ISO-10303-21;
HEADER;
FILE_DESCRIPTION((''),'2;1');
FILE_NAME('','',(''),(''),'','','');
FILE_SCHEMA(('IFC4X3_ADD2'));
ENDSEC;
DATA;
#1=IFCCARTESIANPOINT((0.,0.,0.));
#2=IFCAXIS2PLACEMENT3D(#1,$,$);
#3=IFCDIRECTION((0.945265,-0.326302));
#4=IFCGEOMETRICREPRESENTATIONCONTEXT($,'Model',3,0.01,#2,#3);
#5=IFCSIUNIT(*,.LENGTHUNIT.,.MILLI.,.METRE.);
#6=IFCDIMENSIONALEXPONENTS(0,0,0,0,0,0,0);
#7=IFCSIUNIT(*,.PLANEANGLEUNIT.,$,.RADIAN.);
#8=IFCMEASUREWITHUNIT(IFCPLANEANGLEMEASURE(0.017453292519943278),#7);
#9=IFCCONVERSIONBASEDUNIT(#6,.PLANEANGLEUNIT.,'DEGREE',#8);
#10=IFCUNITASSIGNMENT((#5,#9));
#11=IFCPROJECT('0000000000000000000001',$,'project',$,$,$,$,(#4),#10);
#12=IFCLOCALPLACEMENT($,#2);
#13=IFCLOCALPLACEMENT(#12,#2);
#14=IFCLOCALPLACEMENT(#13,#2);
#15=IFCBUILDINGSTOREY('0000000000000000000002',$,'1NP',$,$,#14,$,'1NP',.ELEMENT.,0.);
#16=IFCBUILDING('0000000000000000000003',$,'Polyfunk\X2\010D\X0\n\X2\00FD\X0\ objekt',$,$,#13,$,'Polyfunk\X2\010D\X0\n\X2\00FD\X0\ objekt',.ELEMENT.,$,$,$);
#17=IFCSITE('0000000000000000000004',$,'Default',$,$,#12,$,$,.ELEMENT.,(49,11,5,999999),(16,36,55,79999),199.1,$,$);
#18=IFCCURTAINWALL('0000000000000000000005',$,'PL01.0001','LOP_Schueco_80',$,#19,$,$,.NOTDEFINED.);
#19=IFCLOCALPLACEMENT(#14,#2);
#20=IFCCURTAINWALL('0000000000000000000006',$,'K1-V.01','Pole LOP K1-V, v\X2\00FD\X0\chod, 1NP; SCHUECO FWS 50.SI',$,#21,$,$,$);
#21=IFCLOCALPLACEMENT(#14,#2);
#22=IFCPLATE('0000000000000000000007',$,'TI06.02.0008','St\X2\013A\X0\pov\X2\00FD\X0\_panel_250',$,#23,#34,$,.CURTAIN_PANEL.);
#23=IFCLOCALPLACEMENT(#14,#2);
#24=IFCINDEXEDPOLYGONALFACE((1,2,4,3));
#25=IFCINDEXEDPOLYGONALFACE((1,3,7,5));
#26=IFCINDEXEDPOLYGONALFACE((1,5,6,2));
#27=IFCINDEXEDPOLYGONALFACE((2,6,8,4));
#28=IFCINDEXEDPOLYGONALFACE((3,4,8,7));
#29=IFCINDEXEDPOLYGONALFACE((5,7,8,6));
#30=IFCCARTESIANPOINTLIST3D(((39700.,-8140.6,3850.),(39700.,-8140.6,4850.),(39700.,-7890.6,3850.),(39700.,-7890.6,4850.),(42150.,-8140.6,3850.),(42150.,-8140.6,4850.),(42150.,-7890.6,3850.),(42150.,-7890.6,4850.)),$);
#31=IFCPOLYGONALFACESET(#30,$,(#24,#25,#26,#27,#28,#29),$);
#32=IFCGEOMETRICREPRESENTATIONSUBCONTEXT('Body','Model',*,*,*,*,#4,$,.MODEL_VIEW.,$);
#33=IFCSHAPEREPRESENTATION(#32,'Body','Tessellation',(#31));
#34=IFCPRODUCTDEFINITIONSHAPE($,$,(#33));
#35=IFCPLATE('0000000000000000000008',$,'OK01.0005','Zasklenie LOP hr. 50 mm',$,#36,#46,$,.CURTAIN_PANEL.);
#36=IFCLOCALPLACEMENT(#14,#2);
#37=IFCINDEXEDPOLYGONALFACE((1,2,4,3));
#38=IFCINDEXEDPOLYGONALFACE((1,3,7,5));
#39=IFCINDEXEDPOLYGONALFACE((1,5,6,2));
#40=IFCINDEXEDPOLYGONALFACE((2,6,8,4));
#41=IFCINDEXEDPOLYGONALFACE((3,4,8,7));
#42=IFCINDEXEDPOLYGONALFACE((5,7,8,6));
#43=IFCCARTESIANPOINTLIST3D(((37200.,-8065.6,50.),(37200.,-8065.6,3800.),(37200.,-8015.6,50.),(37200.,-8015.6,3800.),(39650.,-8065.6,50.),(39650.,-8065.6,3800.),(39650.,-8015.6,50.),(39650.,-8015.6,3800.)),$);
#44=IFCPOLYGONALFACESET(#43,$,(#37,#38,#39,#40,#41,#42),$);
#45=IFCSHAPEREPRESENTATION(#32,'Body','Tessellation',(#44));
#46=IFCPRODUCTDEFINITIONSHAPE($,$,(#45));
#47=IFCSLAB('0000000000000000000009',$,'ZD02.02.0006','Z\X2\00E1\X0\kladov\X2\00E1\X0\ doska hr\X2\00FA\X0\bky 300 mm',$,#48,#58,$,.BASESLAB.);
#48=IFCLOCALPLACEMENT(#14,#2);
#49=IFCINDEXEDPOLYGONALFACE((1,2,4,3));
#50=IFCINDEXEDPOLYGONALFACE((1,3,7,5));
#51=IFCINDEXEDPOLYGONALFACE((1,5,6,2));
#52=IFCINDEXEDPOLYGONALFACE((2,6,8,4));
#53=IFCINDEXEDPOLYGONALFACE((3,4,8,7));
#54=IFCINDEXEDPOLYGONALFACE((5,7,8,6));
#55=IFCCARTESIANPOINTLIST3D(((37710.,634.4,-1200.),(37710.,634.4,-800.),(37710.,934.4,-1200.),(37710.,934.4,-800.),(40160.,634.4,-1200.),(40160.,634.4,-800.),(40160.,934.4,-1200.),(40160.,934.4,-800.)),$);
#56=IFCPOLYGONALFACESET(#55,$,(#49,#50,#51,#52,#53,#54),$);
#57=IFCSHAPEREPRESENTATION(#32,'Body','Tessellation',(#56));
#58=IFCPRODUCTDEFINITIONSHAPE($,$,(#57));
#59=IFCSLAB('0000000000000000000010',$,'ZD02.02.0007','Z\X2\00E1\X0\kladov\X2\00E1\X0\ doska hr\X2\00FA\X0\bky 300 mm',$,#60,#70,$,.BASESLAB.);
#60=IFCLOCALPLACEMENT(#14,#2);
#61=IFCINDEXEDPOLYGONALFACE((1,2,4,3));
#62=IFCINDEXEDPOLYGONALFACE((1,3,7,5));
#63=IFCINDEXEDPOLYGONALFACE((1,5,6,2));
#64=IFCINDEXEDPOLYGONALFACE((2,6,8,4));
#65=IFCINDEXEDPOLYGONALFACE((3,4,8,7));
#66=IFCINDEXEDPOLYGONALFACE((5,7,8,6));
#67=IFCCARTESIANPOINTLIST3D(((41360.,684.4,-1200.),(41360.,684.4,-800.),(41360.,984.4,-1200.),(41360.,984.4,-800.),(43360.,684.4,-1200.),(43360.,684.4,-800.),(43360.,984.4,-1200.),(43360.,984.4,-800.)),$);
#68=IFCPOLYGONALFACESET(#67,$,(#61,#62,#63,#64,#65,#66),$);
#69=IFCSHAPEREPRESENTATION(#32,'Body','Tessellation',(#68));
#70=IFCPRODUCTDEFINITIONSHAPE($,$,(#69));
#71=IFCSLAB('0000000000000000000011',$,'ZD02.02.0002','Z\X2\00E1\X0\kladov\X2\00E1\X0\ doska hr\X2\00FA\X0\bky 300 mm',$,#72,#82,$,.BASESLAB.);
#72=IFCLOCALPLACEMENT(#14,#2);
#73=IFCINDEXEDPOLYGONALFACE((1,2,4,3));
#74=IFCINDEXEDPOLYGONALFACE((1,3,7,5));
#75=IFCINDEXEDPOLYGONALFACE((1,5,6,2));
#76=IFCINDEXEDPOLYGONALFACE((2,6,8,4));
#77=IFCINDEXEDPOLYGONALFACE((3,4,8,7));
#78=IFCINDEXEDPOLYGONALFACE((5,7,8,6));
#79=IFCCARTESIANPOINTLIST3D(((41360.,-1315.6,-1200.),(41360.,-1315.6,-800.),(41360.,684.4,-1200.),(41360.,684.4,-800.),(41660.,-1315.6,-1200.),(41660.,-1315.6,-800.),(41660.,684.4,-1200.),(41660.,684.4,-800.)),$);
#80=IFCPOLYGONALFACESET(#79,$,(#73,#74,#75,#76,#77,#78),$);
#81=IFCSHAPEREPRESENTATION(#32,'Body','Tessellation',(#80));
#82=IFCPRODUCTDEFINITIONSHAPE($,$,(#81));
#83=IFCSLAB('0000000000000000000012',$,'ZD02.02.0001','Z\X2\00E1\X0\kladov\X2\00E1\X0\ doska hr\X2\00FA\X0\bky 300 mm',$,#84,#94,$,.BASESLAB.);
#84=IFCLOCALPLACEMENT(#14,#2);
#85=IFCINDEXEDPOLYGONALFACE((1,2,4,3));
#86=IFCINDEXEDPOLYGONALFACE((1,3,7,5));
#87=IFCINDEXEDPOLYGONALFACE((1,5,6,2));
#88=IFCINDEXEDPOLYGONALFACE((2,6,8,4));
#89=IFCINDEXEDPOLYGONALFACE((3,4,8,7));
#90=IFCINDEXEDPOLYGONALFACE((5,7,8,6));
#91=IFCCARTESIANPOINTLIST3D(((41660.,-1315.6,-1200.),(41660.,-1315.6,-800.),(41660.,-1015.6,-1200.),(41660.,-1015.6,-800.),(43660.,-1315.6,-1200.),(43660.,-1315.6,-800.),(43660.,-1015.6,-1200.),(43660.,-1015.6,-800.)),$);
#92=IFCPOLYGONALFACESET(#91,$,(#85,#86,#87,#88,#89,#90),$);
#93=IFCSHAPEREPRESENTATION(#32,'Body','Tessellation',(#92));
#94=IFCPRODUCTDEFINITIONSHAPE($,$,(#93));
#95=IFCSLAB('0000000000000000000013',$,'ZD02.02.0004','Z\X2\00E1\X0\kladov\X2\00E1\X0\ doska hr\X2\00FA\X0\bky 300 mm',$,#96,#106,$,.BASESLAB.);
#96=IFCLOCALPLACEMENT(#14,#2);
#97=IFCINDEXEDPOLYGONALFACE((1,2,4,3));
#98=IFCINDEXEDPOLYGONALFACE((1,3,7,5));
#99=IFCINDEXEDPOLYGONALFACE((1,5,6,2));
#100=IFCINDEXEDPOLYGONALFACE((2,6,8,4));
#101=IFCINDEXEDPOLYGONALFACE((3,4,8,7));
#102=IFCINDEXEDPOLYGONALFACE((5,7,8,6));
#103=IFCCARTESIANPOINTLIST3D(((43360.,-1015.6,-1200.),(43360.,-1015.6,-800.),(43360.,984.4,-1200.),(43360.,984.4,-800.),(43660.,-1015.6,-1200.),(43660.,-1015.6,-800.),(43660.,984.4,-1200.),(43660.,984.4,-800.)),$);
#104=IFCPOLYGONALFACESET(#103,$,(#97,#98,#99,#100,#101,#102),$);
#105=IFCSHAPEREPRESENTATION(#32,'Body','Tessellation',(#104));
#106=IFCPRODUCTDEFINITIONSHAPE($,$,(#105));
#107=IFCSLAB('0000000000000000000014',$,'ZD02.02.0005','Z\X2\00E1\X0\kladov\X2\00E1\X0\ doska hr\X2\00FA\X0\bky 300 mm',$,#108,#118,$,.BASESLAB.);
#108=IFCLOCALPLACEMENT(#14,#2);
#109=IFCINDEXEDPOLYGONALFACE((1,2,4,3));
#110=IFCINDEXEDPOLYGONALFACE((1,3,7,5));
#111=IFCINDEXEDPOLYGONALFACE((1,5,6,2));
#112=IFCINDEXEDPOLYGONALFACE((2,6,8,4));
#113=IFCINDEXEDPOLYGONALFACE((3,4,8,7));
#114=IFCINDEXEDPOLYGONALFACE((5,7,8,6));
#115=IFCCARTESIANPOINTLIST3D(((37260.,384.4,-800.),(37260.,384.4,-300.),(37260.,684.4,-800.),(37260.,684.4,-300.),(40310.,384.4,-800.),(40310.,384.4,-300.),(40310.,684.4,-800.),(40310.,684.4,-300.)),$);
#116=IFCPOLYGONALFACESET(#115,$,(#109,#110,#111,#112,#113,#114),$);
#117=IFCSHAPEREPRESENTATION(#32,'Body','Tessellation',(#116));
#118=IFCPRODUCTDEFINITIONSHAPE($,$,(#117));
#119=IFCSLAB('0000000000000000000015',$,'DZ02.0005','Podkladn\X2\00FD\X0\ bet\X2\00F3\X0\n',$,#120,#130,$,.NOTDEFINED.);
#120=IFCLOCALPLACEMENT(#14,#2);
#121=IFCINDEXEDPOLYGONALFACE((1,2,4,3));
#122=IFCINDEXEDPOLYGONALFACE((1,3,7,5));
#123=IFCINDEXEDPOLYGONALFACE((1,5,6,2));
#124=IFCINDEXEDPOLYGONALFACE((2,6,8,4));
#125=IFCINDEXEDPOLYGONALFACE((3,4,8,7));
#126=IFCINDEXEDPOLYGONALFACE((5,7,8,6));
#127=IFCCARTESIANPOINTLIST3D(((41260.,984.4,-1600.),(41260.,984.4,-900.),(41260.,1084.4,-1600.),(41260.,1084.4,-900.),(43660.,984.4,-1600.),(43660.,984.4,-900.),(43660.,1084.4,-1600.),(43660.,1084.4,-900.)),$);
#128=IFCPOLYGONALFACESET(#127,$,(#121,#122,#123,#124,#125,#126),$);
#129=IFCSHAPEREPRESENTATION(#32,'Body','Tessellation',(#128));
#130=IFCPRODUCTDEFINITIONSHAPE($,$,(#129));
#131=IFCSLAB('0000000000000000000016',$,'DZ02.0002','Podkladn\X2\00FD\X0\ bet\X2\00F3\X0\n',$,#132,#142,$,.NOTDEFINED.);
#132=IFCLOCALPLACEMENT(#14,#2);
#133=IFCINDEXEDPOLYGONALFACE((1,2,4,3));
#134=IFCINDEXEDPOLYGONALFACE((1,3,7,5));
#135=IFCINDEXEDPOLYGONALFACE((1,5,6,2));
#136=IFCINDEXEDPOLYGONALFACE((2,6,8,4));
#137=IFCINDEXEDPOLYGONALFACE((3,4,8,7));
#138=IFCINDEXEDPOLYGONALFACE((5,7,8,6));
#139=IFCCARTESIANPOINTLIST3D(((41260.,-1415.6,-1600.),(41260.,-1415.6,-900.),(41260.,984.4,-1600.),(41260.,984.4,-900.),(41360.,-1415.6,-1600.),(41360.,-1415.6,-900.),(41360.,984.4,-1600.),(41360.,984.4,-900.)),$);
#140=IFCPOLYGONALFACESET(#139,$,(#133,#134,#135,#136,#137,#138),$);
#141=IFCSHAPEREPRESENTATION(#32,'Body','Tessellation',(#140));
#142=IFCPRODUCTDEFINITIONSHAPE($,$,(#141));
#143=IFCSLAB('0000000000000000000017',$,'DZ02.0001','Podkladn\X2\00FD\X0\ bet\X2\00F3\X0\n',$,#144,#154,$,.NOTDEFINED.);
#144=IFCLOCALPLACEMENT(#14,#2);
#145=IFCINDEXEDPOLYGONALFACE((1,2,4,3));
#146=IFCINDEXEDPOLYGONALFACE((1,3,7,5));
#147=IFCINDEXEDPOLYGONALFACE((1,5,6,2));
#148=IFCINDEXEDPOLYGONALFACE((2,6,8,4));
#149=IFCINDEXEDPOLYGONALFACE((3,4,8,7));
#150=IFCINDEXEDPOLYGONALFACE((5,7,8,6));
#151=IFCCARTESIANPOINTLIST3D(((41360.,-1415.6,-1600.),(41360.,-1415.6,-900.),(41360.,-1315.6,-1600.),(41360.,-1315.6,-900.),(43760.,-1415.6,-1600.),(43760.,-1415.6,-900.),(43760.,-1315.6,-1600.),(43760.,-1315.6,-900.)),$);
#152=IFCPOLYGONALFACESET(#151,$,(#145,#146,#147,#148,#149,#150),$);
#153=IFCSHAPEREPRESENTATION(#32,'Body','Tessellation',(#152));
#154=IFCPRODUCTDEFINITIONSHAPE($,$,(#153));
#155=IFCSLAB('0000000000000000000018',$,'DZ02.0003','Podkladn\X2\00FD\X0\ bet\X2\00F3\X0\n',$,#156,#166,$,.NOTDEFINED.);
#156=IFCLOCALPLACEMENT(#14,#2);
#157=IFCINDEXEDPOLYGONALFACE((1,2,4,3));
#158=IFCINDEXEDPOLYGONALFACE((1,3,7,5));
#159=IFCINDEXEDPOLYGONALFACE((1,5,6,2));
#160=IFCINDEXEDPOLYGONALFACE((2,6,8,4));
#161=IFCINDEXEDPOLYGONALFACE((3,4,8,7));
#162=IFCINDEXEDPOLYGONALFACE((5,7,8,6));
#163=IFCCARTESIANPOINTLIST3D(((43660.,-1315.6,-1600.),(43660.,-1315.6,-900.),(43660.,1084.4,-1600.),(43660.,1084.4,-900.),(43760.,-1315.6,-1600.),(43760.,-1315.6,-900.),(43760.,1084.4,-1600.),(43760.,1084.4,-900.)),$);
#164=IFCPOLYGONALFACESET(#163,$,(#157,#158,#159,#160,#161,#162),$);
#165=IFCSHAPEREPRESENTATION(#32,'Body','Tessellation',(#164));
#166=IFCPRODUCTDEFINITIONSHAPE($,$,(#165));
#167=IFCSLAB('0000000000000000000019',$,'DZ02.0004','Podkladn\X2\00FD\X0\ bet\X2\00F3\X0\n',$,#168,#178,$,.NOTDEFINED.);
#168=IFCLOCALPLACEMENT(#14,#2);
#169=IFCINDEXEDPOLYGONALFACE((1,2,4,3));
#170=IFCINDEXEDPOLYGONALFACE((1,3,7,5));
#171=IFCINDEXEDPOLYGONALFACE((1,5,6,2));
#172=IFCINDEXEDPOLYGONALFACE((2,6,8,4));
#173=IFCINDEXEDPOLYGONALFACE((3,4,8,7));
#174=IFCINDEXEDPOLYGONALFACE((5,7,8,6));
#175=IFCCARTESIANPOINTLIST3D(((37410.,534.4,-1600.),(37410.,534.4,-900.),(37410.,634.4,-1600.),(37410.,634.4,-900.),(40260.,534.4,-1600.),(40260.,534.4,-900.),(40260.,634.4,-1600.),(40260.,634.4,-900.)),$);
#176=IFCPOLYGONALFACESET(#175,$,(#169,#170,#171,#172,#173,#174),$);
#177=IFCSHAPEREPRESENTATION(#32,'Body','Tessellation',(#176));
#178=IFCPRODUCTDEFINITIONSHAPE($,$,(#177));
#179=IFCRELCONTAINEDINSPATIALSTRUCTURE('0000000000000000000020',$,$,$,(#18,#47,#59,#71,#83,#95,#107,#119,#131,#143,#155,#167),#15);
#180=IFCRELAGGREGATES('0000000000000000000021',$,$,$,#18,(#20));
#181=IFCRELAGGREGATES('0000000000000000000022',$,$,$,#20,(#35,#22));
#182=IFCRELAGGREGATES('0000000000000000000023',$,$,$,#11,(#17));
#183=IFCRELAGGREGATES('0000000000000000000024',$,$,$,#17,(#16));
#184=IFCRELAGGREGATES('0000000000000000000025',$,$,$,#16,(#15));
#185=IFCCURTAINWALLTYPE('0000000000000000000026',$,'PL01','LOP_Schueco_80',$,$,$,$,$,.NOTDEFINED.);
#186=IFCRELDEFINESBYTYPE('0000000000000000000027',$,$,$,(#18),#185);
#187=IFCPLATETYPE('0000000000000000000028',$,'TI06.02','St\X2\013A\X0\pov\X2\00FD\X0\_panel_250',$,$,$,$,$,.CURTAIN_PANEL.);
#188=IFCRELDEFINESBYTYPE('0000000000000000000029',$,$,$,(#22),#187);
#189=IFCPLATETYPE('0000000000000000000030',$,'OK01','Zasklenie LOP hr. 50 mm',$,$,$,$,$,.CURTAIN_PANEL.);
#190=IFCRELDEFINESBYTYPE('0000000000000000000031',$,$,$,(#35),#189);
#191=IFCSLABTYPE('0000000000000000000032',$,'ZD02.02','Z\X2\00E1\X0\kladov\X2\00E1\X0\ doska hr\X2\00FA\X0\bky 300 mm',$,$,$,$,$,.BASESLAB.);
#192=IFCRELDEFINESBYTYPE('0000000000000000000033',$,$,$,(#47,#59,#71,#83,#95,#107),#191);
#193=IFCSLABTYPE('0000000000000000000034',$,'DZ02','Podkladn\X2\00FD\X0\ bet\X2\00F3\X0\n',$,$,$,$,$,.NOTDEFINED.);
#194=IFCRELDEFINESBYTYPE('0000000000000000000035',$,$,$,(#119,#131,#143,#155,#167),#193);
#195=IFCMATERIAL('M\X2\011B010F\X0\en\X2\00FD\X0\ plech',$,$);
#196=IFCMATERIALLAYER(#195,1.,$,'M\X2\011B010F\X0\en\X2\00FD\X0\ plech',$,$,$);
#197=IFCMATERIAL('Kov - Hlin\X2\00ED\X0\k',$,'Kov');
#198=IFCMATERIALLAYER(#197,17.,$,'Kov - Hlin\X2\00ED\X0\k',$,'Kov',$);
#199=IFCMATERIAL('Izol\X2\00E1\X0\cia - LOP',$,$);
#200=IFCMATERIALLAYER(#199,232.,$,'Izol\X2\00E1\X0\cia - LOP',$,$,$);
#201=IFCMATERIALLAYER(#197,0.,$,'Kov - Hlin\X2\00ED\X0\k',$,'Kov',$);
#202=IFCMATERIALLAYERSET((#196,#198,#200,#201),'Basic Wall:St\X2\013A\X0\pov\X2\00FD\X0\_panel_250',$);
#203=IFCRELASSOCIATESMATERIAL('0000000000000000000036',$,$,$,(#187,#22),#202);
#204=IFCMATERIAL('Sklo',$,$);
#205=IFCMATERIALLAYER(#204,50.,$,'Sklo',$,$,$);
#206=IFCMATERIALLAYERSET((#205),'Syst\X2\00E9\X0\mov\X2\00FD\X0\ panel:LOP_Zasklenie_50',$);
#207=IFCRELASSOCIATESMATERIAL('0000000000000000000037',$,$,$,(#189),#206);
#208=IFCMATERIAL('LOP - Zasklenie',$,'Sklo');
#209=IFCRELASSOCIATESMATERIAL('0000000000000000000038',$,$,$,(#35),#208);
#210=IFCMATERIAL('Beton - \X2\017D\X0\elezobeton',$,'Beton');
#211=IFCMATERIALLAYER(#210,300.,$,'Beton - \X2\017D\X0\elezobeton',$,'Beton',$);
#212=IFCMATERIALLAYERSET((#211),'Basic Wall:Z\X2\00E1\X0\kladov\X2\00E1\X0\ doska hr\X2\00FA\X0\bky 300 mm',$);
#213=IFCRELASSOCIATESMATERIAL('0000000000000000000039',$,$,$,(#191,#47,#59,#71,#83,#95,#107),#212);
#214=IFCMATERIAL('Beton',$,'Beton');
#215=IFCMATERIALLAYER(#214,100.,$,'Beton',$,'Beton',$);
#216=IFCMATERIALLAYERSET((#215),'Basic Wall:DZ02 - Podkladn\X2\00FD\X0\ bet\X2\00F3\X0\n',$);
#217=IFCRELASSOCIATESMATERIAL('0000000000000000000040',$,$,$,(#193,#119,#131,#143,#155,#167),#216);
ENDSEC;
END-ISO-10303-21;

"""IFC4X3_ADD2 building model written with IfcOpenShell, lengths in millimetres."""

from ifc_helpers import new_model, entity, si_unit, converted_unit, direction, frame, frame_2d, origin, place, context, subcontext, project, spatial, rectangle, extrude, source, transform, mapped, material, layer, layer_set, layer_usage, type_object, type_shapes, element, aggregate, save


model = new_model("IFC4X3_ADD2")

# Units and contexts
model_context = context("Model", 3, precision=0.01, world=origin(), true_north=direction((0.945265, -0.326302)))
body_context = subcontext(model_context, "Body", "Model", "MODEL_VIEW")
ifc_project = project(units=[si_unit("LENGTHUNIT", "METRE", prefix="MILLI"), converted_unit("PLANEANGLEUNIT", "DEGREE", entity("IfcPlaneAngleMeasure", 0.017453292519943278), si_unit("PLANEANGLEUNIT", "RADIAN"), dimensions=[0, 0, 0, 0, 0, 0, 0])], contexts=[model_context])

# Site, building, storey
site_placement = place(None, origin())
site = spatial("IfcSite", under=ifc_project, at=site_placement, Name="Default", CompositionType="ELEMENT", RefLatitude=(49, 11, 5, 999999), RefLongitude=(16, 36, 55, 79999), RefElevation=199.1)
building_placement = place(site_placement, origin())
building = spatial("IfcBuilding", under=site, at=building_placement, Name="Polyfunkčný objekt", LongName="Polyfunkčný objekt", CompositionType="ELEMENT")
storey_placement = place(building_placement, origin())
storey = spatial("IfcBuildingStorey", under=building, at=storey_placement, Name="1NP", LongName="1NP", CompositionType="ELEMENT", Elevation=0.0)

# Curtain walls, plates
curtain_wall_type = type_object("IfcCurtainWallType", Name="PL01", Description="LOP_Schueco_80", PredefinedType="NOTDEFINED")
curtain_wall_1_placement = place(storey_placement, origin())
curtain_wall_1 = element("IfcCurtainWall", 1, at=curtain_wall_1_placement, inside=storey, type_object=curtain_wall_type, Name="PL01.0001", Description="LOP_Schueco_80", PredefinedType="NOTDEFINED")
curtain_wall_2 = element("IfcCurtainWall", 2, Name="K1-V.01", Description="Pole LOP K1-V, východ, 1NP; SCHUECO FWS 50.SI")
aggregate(curtain_wall_1, [curtain_wall_2])
ifc_material_1 = material(Name="Měďený plech")
ifc_layer_1 = layer(ifc_material_1, 1.0, Name="Měďený plech")
ifc_material_2 = material(Name="Kov - Hliník", Category="Kov")
ifc_layer_2 = layer(ifc_material_2, 17.0, Name="Kov - Hliník", Category="Kov")
ifc_material_3 = material(Name="Izolácia - LOP")
ifc_layer_3 = layer(ifc_material_3, 232.0, Name="Izolácia - LOP")
ifc_layer_4 = layer(ifc_material_2, 0.0, Name="Kov - Hliník", Category="Kov")
ifc_layer_set_1 = layer_set([ifc_layer_1, ifc_layer_2, ifc_layer_3, ifc_layer_4], Name="Basic Wall:Stĺpový_panel_250")
ifc_layer_usage = layer_usage(ifc_layer_set_1, "AXIS2", "POSITIVE", -125.0)
plate_type_1 = type_object("IfcPlateType", Name="TI06.02", Description="Stĺpový_panel_250", PredefinedType="CURTAIN_PANEL", material=ifc_layer_set_1)
plate_1_placement = place(storey_placement, frame((39700.0, -8015.6, 3850.0)))
plate_1 = element("IfcPlate", 3, at=plate_1_placement, type_object=plate_type_1, material=ifc_layer_usage, Name="TI06.02.0008", Description="Stĺpový_panel_250", PredefinedType="CURTAIN_PANEL", context=body_context, shape_type="SweptSolid", body=[
    extrude(rectangle(XDim=250.0, YDim=2450.0, at=frame_2d((0.0, 0.0), x_axis=(1.0, 0.0))), frame((1225.0, 0.0, 0.0), z_axis=(0.0, 0.0, 1.0), x_axis=(0.0, 1.0, 0.0)), (0.0, 0.0, 1.0), 1000.0),
])
ifc_material_4 = material(Name="LOP - Zasklenie", Category="Sklo")
ifc_material_5 = material(Name="Sklo")
ifc_layer_5 = layer(ifc_material_5, 50.0, Name="Sklo")
ifc_layer_set_2 = layer_set([ifc_layer_5], Name="Systémový panel:LOP_Zasklenie_50")
plate_type_2 = type_object("IfcPlateType", Name="OK01", Description="Zasklenie LOP hr. 50 mm", PredefinedType="CURTAIN_PANEL", material=ifc_layer_set_2)
shared_shape_1 = source(origin(), body_context, "Body", "SweptSolid", [
    extrude(rectangle(XDim=3750.0, YDim=2450.0, at=frame_2d((-331.2, 0.0), x_axis=(1.0, 0.0))), frame((0.0, -50.0, 2206.2), z_axis=(0.0, 1.0, 0.0), x_axis=(0.0, 0.0, 1.0)), (0.0, 0.0, 1.0), 50.0),
])
type_shapes(plate_type_2, [shared_shape_1])
plate_2_placement = place(curtain_wall_1_placement, frame((38425.0, -8015.6, 50.0)))
plate_2 = element("IfcPlate", 4, at=plate_2_placement, type_object=plate_type_2, material=ifc_material_4, Name="OK01.0005", Description="Zasklenie LOP hr. 50 mm", PredefinedType="CURTAIN_PANEL", context=body_context, shape_type="MappedRepresentation", body=[
    mapped(shared_shape_1, transform((0.0, 0.0, 0.0), scale=1.0)),
])
aggregate(curtain_wall_2, [plate_2, plate_1])

# Slabs
ifc_material_6 = material(Name="Beton - Železobeton", Category="Beton")
ifc_layer_6 = layer(ifc_material_6, 300.0, Name="Beton - Železobeton", Category="Beton")
ifc_layer_set_3 = layer_set([ifc_layer_6], Name="Basic Wall:Základová doska hrúbky 300 mm")
slab_type_1 = type_object("IfcSlabType", Name="ZD02.02", Description="Základová doska hrúbky 300 mm", PredefinedType="BASESLAB", material=ifc_layer_set_3)
slab_1_placement = place(storey_placement, frame((40160.0, 784.4, -1200.0), z_axis=(0.0, 0.0, 1.0), x_axis=(-1.0, 0.0, 0.0)))
element("IfcSlab", 5, at=slab_1_placement, inside=storey, type_object=slab_type_1, material=ifc_layer_set_3, Name="ZD02.02.0006", Description="Základová doska hrúbky 300 mm", PredefinedType="BASESLAB", context=body_context, shape_type="SweptSolid", body=[
    extrude(rectangle(XDim=2450.0, YDim=300.0, at=frame_2d((1225.0, 0.0), x_axis=(-1.0, 0.0))), origin(), (0.0, 0.0, 1.0), 400.0),
])
slab_2_placement = place(storey_placement, frame((41360.0, 834.4, -1200.0)))
element("IfcSlab", 6, at=slab_2_placement, inside=storey, type_object=slab_type_1, material=ifc_layer_set_3, Name="ZD02.02.0007", Description="Základová doska hrúbky 300 mm", PredefinedType="BASESLAB", context=body_context, shape_type="SweptSolid", body=[
    extrude(rectangle(XDim=2000.0, YDim=300.0, at=frame_2d((1000.0, 0.0), x_axis=(-1.0, 0.0))), origin(), (0.0, 0.0, 1.0), 400.0),
])
slab_3_placement = place(storey_placement, frame((41510.0, -1315.6, -1200.0), z_axis=(0.0, 0.0, 1.0), x_axis=(0.0, 1.0, 0.0)))
element("IfcSlab", 7, at=slab_3_placement, inside=storey, type_object=slab_type_1, material=ifc_layer_set_3, Name="ZD02.02.0002", Description="Základová doska hrúbky 300 mm", PredefinedType="BASESLAB", context=body_context, shape_type="SweptSolid", body=[
    extrude(rectangle(XDim=2000.0, YDim=300.0, at=frame_2d((1000.0, 0.0), x_axis=(-1.0, 0.0))), origin(), (0.0, 0.0, 1.0), 400.0),
])
slab_4_placement = place(storey_placement, frame((43660.0, -1165.6, -1200.0), z_axis=(0.0, 0.0, 1.0), x_axis=(-1.0, 0.0, 0.0)))
element("IfcSlab", 8, at=slab_4_placement, inside=storey, type_object=slab_type_1, material=ifc_layer_set_3, Name="ZD02.02.0001", Description="Základová doska hrúbky 300 mm", PredefinedType="BASESLAB", context=body_context, shape_type="SweptSolid", body=[
    extrude(rectangle(XDim=2000.0, YDim=300.0, at=frame_2d((1000.0, 0.0), x_axis=(-1.0, 0.0))), origin(), (0.0, 0.0, 1.0), 400.0),
])
slab_5_placement = place(storey_placement, frame((43510.0, 984.4, -1200.0), z_axis=(0.0, 0.0, 1.0), x_axis=(0.0, -1.0, 0.0)))
element("IfcSlab", 9, at=slab_5_placement, inside=storey, type_object=slab_type_1, material=ifc_layer_set_3, Name="ZD02.02.0004", Description="Základová doska hrúbky 300 mm", PredefinedType="BASESLAB", context=body_context, shape_type="SweptSolid", body=[
    extrude(rectangle(XDim=2000.0, YDim=300.0, at=frame_2d((1000.0, 0.0), x_axis=(-1.0, 0.0))), origin(), (0.0, 0.0, 1.0), 400.0),
])
slab_6_placement = place(storey_placement, frame((40310.0, 534.4, -800.0), z_axis=(0.0, 0.0, 1.0), x_axis=(-1.0, 0.0, 0.0)))
element("IfcSlab", 10, at=slab_6_placement, inside=storey, type_object=slab_type_1, material=ifc_layer_set_3, Name="ZD02.02.0005", Description="Základová doska hrúbky 300 mm", PredefinedType="BASESLAB", context=body_context, shape_type="SweptSolid", body=[
    extrude(rectangle(XDim=3050.0, YDim=300.0, at=frame_2d((1525.0, 0.0), x_axis=(-1.0, 0.0))), origin(), (0.0, 0.0, 1.0), 500.0),
])
ifc_material_7 = material(Name="Beton", Category="Beton")
ifc_layer_7 = layer(ifc_material_7, 100.0, Name="Beton", Category="Beton")
ifc_layer_set_4 = layer_set([ifc_layer_7], Name="Basic Wall:DZ02 - Podkladný betón")
slab_type_2 = type_object("IfcSlabType", Name="DZ02", Description="Podkladný betón", PredefinedType="NOTDEFINED", material=ifc_layer_set_4)
slab_7_placement = place(storey_placement, frame((41260.0, 1034.4, -1600.0)))
element("IfcSlab", 11, at=slab_7_placement, inside=storey, type_object=slab_type_2, material=ifc_layer_set_4, Name="DZ02.0005", Description="Podkladný betón", PredefinedType="NOTDEFINED", context=body_context, shape_type="SweptSolid", body=[
    extrude(rectangle(XDim=2400.0, YDim=100.0, at=frame_2d((1200.0, 0.0), x_axis=(-1.0, 0.0))), origin(), (0.0, 0.0, 1.0), 700.0),
])
slab_8_placement = place(storey_placement, frame((41310.0, -1415.6, -1600.0), z_axis=(0.0, 0.0, 1.0), x_axis=(0.0, 1.0, 0.0)))
element("IfcSlab", 12, at=slab_8_placement, inside=storey, type_object=slab_type_2, material=ifc_layer_set_4, Name="DZ02.0002", Description="Podkladný betón", PredefinedType="NOTDEFINED", context=body_context, shape_type="SweptSolid", body=[
    extrude(rectangle(XDim=2400.0, YDim=100.0, at=frame_2d((1200.0, 0.0), x_axis=(-1.0, 0.0))), origin(), (0.0, 0.0, 1.0), 700.0),
])
slab_9_placement = place(storey_placement, frame((43760.0, -1365.6, -1600.0), z_axis=(0.0, 0.0, 1.0), x_axis=(-1.0, 0.0, 0.0)))
element("IfcSlab", 13, at=slab_9_placement, inside=storey, type_object=slab_type_2, material=ifc_layer_set_4, Name="DZ02.0001", Description="Podkladný betón", PredefinedType="NOTDEFINED", context=body_context, shape_type="SweptSolid", body=[
    extrude(rectangle(XDim=2400.0, YDim=100.0, at=frame_2d((1200.0, 0.0), x_axis=(-1.0, 0.0))), origin(), (0.0, 0.0, 1.0), 700.0),
])
slab_10_placement = place(storey_placement, frame((43710.0, 1084.4, -1600.0), z_axis=(0.0, 0.0, 1.0), x_axis=(0.0, -1.0, 0.0)))
element("IfcSlab", 14, at=slab_10_placement, inside=storey, type_object=slab_type_2, material=ifc_layer_set_4, Name="DZ02.0003", Description="Podkladný betón", PredefinedType="NOTDEFINED", context=body_context, shape_type="SweptSolid", body=[
    extrude(rectangle(XDim=2400.0, YDim=100.0, at=frame_2d((1200.0, 0.0), x_axis=(-1.0, 0.0))), origin(), (0.0, 0.0, 1.0), 700.0),
])
slab_11_placement = place(storey_placement, frame((40260.0, 584.4, -1600.0), z_axis=(0.0, 0.0, 1.0), x_axis=(-1.0, 0.0, 0.0)))
element("IfcSlab", 15, at=slab_11_placement, inside=storey, type_object=slab_type_2, material=ifc_layer_set_4, Name="DZ02.0004", Description="Podkladný betón", PredefinedType="NOTDEFINED", context=body_context, shape_type="SweptSolid", body=[
    extrude(rectangle(XDim=2850.0, YDim=100.0, at=frame_2d((1425.0, 0.0), x_axis=(-1.0, 0.0))), origin(), (0.0, 0.0, 1.0), 700.0),
])

save(model, "model.ifc")
